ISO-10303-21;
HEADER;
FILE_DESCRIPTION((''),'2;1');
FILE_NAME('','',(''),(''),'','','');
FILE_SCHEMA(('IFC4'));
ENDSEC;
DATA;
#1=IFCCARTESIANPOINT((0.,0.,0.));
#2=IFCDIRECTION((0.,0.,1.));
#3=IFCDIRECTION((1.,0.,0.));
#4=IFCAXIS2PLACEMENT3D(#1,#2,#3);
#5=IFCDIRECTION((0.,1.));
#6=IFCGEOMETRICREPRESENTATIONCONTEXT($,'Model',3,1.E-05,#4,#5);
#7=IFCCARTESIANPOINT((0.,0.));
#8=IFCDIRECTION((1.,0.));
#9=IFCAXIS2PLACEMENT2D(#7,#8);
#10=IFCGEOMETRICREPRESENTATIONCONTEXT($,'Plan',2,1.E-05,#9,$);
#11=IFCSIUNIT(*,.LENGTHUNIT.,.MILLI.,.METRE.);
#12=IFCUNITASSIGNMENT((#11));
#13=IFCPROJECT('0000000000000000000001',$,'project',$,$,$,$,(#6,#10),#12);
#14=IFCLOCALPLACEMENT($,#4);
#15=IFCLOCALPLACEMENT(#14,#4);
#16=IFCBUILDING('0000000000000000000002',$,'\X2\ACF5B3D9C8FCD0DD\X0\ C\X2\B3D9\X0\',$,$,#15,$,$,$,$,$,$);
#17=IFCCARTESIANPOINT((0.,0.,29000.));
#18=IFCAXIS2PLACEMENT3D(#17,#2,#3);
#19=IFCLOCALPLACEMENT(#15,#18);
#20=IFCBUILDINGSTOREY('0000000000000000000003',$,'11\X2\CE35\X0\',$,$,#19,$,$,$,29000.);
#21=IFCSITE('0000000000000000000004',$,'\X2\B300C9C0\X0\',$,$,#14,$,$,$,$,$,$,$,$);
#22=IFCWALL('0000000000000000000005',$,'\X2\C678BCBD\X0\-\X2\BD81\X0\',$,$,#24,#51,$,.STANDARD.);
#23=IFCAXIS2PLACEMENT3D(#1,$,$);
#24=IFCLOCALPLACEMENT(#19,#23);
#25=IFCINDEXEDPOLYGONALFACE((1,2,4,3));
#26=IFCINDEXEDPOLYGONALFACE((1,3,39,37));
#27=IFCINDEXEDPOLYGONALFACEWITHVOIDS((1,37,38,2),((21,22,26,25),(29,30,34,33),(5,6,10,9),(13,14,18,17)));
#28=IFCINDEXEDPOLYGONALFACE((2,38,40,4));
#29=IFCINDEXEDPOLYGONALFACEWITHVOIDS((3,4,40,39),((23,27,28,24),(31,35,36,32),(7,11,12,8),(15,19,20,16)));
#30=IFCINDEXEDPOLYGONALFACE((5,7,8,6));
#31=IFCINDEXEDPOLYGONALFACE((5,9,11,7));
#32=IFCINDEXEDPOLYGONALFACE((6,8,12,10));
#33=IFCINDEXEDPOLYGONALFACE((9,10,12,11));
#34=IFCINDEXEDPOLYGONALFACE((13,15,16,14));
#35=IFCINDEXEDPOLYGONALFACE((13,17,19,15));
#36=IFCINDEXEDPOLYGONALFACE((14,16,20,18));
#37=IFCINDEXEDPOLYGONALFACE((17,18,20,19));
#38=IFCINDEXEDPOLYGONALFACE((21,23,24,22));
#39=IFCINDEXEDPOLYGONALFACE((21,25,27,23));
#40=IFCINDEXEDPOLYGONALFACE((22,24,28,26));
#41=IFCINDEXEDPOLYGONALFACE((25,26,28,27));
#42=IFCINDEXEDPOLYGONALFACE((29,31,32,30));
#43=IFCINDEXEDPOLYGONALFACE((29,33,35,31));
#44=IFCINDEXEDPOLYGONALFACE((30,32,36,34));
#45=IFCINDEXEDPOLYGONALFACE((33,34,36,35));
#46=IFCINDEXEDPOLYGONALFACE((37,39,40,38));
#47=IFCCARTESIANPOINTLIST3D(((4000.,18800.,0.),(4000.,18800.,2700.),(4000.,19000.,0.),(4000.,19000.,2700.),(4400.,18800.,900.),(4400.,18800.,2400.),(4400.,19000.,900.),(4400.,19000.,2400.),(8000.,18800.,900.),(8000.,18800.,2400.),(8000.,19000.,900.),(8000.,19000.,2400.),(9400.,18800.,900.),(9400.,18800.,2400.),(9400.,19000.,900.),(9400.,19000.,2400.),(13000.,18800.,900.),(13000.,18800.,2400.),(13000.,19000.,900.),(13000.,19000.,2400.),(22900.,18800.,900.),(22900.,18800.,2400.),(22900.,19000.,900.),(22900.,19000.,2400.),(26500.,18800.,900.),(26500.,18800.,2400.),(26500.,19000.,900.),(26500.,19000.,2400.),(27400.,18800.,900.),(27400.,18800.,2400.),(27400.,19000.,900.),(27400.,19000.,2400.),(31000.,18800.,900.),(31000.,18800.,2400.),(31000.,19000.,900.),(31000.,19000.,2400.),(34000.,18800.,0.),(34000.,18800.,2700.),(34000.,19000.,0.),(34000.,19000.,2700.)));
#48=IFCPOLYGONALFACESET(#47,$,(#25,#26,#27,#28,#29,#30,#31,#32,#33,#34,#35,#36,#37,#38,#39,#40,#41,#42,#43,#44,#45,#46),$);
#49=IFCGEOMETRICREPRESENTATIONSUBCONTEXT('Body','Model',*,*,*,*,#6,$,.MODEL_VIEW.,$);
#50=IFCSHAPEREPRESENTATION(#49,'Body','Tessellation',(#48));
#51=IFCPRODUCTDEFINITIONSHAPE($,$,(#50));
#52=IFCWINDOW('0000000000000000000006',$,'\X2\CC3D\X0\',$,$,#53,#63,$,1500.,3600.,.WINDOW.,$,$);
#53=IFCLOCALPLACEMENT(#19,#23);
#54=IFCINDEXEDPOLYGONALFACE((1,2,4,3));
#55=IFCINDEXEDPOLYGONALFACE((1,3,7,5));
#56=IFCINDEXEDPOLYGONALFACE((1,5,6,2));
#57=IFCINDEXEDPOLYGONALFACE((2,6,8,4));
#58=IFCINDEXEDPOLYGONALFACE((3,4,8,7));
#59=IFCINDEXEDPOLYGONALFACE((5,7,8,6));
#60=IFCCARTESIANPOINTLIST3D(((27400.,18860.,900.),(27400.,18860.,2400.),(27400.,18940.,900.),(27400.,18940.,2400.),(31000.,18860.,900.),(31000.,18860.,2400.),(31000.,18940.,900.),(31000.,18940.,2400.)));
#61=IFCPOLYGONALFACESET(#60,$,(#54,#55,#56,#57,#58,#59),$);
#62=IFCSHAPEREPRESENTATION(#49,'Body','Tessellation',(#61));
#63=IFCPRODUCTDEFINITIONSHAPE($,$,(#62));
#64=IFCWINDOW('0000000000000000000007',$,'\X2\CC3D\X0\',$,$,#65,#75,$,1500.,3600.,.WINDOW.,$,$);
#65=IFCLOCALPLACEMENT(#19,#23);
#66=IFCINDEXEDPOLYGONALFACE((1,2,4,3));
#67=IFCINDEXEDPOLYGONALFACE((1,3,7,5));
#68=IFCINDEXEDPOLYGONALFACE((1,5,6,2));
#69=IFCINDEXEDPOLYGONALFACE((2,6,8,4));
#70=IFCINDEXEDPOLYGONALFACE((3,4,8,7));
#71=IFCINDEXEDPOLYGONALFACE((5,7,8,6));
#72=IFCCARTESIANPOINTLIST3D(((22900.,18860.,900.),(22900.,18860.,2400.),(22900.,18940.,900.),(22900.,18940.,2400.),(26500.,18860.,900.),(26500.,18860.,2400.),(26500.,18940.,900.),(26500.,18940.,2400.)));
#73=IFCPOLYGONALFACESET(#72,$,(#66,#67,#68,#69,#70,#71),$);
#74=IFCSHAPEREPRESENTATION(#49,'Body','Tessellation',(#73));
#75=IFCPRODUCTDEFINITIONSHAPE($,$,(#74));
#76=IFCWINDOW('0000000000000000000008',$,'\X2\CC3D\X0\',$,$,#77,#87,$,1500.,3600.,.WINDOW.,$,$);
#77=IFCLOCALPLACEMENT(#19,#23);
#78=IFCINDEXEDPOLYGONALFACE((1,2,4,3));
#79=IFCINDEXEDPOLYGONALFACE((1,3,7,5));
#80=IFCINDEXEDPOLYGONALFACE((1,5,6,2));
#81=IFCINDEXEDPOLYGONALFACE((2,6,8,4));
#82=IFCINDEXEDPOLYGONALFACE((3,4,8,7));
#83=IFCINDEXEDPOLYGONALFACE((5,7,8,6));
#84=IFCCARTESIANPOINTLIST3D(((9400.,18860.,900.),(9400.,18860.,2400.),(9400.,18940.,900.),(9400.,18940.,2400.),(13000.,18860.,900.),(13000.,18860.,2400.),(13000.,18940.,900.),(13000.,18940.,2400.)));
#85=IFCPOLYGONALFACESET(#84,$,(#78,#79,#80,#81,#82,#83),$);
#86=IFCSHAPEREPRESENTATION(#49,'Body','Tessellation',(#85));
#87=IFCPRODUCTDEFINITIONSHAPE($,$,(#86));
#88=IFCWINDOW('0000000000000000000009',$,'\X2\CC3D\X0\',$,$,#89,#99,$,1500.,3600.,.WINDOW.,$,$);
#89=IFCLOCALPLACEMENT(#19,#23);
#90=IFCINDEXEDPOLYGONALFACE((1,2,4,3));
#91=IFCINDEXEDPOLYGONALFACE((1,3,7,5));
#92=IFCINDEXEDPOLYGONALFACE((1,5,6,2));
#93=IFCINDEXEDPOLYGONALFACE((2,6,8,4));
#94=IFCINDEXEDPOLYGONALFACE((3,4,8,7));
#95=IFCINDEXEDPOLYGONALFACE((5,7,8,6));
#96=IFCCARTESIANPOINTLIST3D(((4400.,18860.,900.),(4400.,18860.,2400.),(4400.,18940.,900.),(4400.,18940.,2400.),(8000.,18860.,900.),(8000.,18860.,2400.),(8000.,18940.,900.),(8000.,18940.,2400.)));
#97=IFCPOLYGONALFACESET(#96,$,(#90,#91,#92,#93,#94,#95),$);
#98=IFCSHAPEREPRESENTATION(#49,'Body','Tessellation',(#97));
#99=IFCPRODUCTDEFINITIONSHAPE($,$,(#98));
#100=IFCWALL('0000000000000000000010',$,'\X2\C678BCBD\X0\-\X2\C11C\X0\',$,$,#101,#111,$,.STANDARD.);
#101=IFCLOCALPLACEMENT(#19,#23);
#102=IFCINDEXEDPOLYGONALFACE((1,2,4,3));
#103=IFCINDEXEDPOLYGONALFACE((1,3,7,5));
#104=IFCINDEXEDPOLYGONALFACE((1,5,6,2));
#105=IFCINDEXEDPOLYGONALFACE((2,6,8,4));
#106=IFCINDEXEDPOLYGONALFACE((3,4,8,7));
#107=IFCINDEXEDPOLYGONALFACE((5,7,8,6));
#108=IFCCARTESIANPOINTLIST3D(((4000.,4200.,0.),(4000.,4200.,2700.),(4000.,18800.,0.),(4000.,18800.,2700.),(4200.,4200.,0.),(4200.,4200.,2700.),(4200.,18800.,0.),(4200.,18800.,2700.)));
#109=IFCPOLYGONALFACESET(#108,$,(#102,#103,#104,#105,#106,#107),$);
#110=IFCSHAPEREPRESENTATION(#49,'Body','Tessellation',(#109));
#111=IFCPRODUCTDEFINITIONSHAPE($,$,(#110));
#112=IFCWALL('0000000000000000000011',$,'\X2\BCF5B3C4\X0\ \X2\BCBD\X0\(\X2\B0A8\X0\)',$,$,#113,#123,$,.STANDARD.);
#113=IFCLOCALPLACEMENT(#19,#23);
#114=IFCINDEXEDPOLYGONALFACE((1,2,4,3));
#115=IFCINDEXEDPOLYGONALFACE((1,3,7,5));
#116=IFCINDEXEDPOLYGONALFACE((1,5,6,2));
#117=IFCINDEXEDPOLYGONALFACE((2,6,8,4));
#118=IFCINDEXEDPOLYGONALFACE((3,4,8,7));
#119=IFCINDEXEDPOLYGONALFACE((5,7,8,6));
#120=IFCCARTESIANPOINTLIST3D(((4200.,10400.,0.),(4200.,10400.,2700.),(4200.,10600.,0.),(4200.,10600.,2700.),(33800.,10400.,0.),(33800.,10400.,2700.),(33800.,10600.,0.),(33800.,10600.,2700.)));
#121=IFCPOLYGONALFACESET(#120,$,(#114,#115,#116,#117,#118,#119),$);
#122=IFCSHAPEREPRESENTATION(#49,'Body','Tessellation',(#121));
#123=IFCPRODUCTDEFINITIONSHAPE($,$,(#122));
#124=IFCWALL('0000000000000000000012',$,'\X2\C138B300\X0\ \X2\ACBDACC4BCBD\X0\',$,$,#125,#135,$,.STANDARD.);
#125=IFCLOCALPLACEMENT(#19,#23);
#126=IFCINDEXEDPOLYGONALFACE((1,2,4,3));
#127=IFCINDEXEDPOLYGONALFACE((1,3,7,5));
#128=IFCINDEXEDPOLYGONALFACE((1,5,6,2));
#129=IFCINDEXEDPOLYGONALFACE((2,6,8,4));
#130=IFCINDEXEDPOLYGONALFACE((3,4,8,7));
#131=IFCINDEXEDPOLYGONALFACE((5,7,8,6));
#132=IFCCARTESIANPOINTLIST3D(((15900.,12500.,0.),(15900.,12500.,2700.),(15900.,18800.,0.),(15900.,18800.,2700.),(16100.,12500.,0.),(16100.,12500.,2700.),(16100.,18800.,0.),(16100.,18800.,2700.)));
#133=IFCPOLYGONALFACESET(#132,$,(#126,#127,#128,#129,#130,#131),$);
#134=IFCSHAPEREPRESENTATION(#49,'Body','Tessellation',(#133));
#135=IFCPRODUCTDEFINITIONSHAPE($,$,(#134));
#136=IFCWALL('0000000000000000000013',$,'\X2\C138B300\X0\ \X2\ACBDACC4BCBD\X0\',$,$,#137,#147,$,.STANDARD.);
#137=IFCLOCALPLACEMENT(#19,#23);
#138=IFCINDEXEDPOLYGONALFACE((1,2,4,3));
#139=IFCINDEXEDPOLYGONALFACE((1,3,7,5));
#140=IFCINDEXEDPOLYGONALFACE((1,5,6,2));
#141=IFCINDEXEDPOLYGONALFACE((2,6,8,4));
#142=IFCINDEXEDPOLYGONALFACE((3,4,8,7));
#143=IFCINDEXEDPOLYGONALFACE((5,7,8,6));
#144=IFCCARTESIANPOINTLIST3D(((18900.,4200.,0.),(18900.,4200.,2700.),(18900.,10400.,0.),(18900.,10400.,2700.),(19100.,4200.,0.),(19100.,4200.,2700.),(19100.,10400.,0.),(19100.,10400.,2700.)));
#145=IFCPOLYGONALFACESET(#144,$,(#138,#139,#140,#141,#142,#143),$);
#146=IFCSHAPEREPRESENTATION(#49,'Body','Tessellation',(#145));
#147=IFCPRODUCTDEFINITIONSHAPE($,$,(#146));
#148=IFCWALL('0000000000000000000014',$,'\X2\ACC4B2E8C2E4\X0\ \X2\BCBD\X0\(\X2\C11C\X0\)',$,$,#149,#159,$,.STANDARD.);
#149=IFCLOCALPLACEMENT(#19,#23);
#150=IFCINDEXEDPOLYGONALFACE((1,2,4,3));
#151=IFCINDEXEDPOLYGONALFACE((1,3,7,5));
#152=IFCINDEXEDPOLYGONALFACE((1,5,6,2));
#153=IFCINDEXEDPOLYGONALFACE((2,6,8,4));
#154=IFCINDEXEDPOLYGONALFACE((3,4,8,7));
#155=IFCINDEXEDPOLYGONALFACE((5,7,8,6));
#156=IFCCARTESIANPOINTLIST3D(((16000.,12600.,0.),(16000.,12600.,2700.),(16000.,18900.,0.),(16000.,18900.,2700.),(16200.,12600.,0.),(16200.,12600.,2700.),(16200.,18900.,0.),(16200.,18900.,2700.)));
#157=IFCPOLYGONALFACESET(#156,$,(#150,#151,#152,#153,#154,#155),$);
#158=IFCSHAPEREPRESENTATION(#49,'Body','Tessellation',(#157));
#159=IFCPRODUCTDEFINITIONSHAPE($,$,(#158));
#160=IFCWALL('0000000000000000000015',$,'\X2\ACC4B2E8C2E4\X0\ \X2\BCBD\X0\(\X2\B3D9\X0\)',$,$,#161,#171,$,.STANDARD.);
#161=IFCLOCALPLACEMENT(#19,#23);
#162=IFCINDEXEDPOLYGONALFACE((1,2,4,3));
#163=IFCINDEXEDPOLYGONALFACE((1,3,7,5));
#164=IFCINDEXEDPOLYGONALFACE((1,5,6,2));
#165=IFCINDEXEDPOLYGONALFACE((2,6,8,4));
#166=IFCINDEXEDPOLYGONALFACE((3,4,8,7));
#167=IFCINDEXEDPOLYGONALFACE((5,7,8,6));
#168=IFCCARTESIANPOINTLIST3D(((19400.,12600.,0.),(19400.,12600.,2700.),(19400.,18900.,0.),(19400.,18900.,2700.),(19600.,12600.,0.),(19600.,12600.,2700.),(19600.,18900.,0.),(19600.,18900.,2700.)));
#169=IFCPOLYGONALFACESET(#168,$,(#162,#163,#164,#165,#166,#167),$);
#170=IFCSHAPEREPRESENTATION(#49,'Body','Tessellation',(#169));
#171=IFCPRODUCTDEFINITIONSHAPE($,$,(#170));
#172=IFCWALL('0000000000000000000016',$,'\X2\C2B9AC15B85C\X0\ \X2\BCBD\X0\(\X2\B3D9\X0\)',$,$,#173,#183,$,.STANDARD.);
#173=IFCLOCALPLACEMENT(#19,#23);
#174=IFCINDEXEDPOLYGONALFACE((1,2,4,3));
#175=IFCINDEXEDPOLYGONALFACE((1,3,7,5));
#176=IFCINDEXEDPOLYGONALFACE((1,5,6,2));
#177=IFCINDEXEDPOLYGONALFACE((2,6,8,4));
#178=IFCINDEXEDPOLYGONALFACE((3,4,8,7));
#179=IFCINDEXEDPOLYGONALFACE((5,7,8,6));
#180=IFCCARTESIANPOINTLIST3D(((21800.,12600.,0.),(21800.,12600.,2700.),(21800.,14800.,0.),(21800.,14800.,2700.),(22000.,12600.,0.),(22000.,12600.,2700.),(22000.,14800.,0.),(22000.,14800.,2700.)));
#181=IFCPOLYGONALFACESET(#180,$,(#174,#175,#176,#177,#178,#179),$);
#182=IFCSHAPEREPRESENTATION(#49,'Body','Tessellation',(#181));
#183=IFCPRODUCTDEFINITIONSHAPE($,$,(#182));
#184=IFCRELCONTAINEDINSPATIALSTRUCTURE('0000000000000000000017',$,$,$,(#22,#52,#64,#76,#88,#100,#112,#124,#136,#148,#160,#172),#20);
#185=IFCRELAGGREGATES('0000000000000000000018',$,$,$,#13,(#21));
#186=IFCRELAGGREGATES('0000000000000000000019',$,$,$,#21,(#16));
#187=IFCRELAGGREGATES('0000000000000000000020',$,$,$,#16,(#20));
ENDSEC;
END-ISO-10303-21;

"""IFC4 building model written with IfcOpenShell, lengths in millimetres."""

from ifc_helpers import new_model, si_unit, direction, frame, origin_with_axes, origin_2d_with_axis, place, context, subcontext, project, spatial, polyline, outline, extrude, element, fill, save


model = new_model("IFC4")

# Units and contexts
model_context = context("Model", 3, precision=1e-05, world=origin_with_axes(), true_north=direction((0.0, 1.0)))
plan_context = context("Plan", 2, precision=1e-05, world=origin_2d_with_axis())
body_context = subcontext(model_context, "Body", "Model", "MODEL_VIEW")
ifc_project = project(units=[si_unit("LENGTHUNIT", "METRE", prefix="MILLI")], contexts=[model_context, plan_context])

# Site, building, storey
site_placement = place(None, origin_with_axes())
site = spatial("IfcSite", under=ifc_project, at=site_placement, Name="대지")
building_placement = place(site_placement, origin_with_axes())
building = spatial("IfcBuilding", under=site, at=building_placement, Name="공동주택 C동")
storey_placement = place(building_placement, frame((0.0, 0.0, 29000.0), z_axis=(0.0, 0.0, 1.0), x_axis=(1.0, 0.0, 0.0)))
storey = spatial("IfcBuildingStorey", under=building, at=storey_placement, Name="11층", Elevation=29000.0)

# Wall, openings, windows
wall_1_placement = place(storey_placement, origin_with_axes())
wall_1 = element("IfcWall", 1, at=wall_1_placement, inside=storey, Name="외벽-북", PredefinedType="STANDARD", context=body_context, shape_type="SweptSolid", body=[
    extrude(outline(polyline([(34000.0, 18800.0), (4000.0, 18800.0), (4000.0, 19000.0), (34000.0, 19000.0), (34000.0, 18800.0)])), origin_with_axes(), (0.0, 0.0, 1.0), 2700.0),
])
opening_1_placement = place(storey_placement, origin_with_axes())
opening_1 = element("IfcOpeningElement", 2, at=opening_1_placement, cuts=wall_1, PredefinedType="OPENING", context=body_context, shape_type="SweptSolid", body=[
    extrude(outline(polyline([(31000.0, 19050.0), (27400.0, 19050.0), (27400.0, 18750.0), (31000.0, 18750.0), (31000.0, 19050.0)])), frame((0.0, 0.0, 900.0), z_axis=(0.0, 0.0, 1.0), x_axis=(1.0, 0.0, 0.0)), (0.0, 0.0, 1.0), 1500.0),
])
opening_2_placement = place(storey_placement, origin_with_axes())
opening_2 = element("IfcOpeningElement", 3, at=opening_2_placement, cuts=wall_1, PredefinedType="OPENING", context=body_context, shape_type="SweptSolid", body=[
    extrude(outline(polyline([(26500.0, 19050.0), (22900.0, 19050.0), (22900.0, 18750.0), (26500.0, 18750.0), (26500.0, 19050.0)])), frame((0.0, 0.0, 900.0), z_axis=(0.0, 0.0, 1.0), x_axis=(1.0, 0.0, 0.0)), (0.0, 0.0, 1.0), 1500.0),
])
opening_3_placement = place(storey_placement, origin_with_axes())
opening_3 = element("IfcOpeningElement", 4, at=opening_3_placement, cuts=wall_1, PredefinedType="OPENING", context=body_context, shape_type="SweptSolid", body=[
    extrude(outline(polyline([(13000.0, 19050.0), (9400.0, 19050.0), (9400.0, 18750.0), (13000.0, 18750.0), (13000.0, 19050.0)])), frame((0.0, 0.0, 900.0), z_axis=(0.0, 0.0, 1.0), x_axis=(1.0, 0.0, 0.0)), (0.0, 0.0, 1.0), 1500.0),
])
opening_4_placement = place(storey_placement, origin_with_axes())
opening_4 = element("IfcOpeningElement", 5, at=opening_4_placement, cuts=wall_1, PredefinedType="OPENING", context=body_context, shape_type="SweptSolid", body=[
    extrude(outline(polyline([(8000.0, 19050.0), (4400.0, 19050.0), (4400.0, 18750.0), (8000.0, 18750.0), (8000.0, 19050.0)])), frame((0.0, 0.0, 900.0), z_axis=(0.0, 0.0, 1.0), x_axis=(1.0, 0.0, 0.0)), (0.0, 0.0, 1.0), 1500.0),
])
window_1_placement = place(storey_placement, origin_with_axes())
window_1 = element("IfcWindow", 6, at=window_1_placement, inside=storey, Name="창", OverallHeight=1500.0, OverallWidth=3600.0, PredefinedType="WINDOW", context=body_context, shape_type="SweptSolid", body=[
    extrude(outline(polyline([(31000.0, 18940.0), (27400.0, 18940.0), (27400.0, 18860.0), (31000.0, 18860.0), (31000.0, 18940.0)])), frame((0.0, 0.0, 900.0), z_axis=(0.0, 0.0, 1.0), x_axis=(1.0, 0.0, 0.0)), (0.0, 0.0, 1.0), 1500.0),
])
fill(opening_1, window_1)
window_2_placement = place(storey_placement, origin_with_axes())
window_2 = element("IfcWindow", 7, at=window_2_placement, inside=storey, Name="창", OverallHeight=1500.0, OverallWidth=3600.0, PredefinedType="WINDOW", context=body_context, shape_type="SweptSolid", body=[
    extrude(outline(polyline([(26500.0, 18940.0), (22900.0, 18940.0), (22900.0, 18860.0), (26500.0, 18860.0), (26500.0, 18940.0)])), frame((0.0, 0.0, 900.0), z_axis=(0.0, 0.0, 1.0), x_axis=(1.0, 0.0, 0.0)), (0.0, 0.0, 1.0), 1500.0),
])
fill(opening_2, window_2)
window_3_placement = place(storey_placement, origin_with_axes())
window_3 = element("IfcWindow", 8, at=window_3_placement, inside=storey, Name="창", OverallHeight=1500.0, OverallWidth=3600.0, PredefinedType="WINDOW", context=body_context, shape_type="SweptSolid", body=[
    extrude(outline(polyline([(13000.0, 18940.0), (9400.0, 18940.0), (9400.0, 18860.0), (13000.0, 18860.0), (13000.0, 18940.0)])), frame((0.0, 0.0, 900.0), z_axis=(0.0, 0.0, 1.0), x_axis=(1.0, 0.0, 0.0)), (0.0, 0.0, 1.0), 1500.0),
])
fill(opening_3, window_3)
window_4_placement = place(storey_placement, origin_with_axes())
window_4 = element("IfcWindow", 9, at=window_4_placement, inside=storey, Name="창", OverallHeight=1500.0, OverallWidth=3600.0, PredefinedType="WINDOW", context=body_context, shape_type="SweptSolid", body=[
    extrude(outline(polyline([(8000.0, 18940.0), (4400.0, 18940.0), (4400.0, 18860.0), (8000.0, 18860.0), (8000.0, 18940.0)])), frame((0.0, 0.0, 900.0), z_axis=(0.0, 0.0, 1.0), x_axis=(1.0, 0.0, 0.0)), (0.0, 0.0, 1.0), 1500.0),
])
fill(opening_4, window_4)

# Walls
wall_2_placement = place(storey_placement, origin_with_axes())
element("IfcWall", 10, at=wall_2_placement, inside=storey, Name="외벽-서", PredefinedType="STANDARD", context=body_context, shape_type="SweptSolid", body=[
    extrude(outline(polyline([(4200.0, 18800.0), (4200.0, 4200.0), (4000.0, 4200.0), (4000.0, 18800.0), (4200.0, 18800.0)])), origin_with_axes(), (0.0, 0.0, 1.0), 2700.0),
])
wall_3_placement = place(storey_placement, origin_with_axes())
element("IfcWall", 11, at=wall_3_placement, inside=storey, Name="복도 벽(남)", PredefinedType="STANDARD", context=body_context, shape_type="SweptSolid", body=[
    extrude(outline(polyline([(4200.0, 10600.0), (33800.0, 10600.0), (33800.0, 10400.0), (4200.0, 10400.0), (4200.0, 10600.0)])), origin_with_axes(), (0.0, 0.0, 1.0), 2700.0),
])
wall_4_placement = place(storey_placement, origin_with_axes())
element("IfcWall", 12, at=wall_4_placement, inside=storey, Name="세대 경계벽", PredefinedType="STANDARD", context=body_context, shape_type="SweptSolid", body=[
    extrude(outline(polyline([(15900.0, 12500.0), (15900.0, 18800.0), (16100.0, 18800.0), (16100.0, 12500.0), (15900.0, 12500.0)])), origin_with_axes(), (0.0, 0.0, 1.0), 2700.0),
])
wall_5_placement = place(storey_placement, origin_with_axes())
element("IfcWall", 13, at=wall_5_placement, inside=storey, Name="세대 경계벽", PredefinedType="STANDARD", context=body_context, shape_type="SweptSolid", body=[
    extrude(outline(polyline([(18900.0, 4200.0), (18900.0, 10400.0), (19100.0, 10400.0), (19100.0, 4200.0), (18900.0, 4200.0)])), origin_with_axes(), (0.0, 0.0, 1.0), 2700.0),
])
wall_6_placement = place(storey_placement, origin_with_axes())
element("IfcWall", 14, at=wall_6_placement, inside=storey, Name="계단실 벽(서)", PredefinedType="STANDARD", context=body_context, shape_type="SweptSolid", body=[
    extrude(outline(polyline([(16000.0, 12600.0), (16000.0, 18900.0), (16200.0, 18900.0), (16200.0, 12600.0), (16000.0, 12600.0)])), origin_with_axes(), (0.0, 0.0, 1.0), 2700.0),
])
wall_7_placement = place(storey_placement, origin_with_axes())
element("IfcWall", 15, at=wall_7_placement, inside=storey, Name="계단실 벽(동)", PredefinedType="STANDARD", context=body_context, shape_type="SweptSolid", body=[
    extrude(outline(polyline([(19400.0, 12600.0), (19400.0, 18900.0), (19600.0, 18900.0), (19600.0, 12600.0), (19400.0, 12600.0)])), origin_with_axes(), (0.0, 0.0, 1.0), 2700.0),
])
wall_8_placement = place(storey_placement, origin_with_axes())
element("IfcWall", 16, at=wall_8_placement, inside=storey, Name="승강로 벽(동)", PredefinedType="STANDARD", context=body_context, shape_type="SweptSolid", body=[
    extrude(outline(polyline([(21800.0, 12600.0), (21800.0, 14800.0), (22000.0, 14800.0), (22000.0, 12600.0), (21800.0, 12600.0)])), origin_with_axes(), (0.0, 0.0, 1.0), 2700.0),
])

save(model, "model.ifc")
